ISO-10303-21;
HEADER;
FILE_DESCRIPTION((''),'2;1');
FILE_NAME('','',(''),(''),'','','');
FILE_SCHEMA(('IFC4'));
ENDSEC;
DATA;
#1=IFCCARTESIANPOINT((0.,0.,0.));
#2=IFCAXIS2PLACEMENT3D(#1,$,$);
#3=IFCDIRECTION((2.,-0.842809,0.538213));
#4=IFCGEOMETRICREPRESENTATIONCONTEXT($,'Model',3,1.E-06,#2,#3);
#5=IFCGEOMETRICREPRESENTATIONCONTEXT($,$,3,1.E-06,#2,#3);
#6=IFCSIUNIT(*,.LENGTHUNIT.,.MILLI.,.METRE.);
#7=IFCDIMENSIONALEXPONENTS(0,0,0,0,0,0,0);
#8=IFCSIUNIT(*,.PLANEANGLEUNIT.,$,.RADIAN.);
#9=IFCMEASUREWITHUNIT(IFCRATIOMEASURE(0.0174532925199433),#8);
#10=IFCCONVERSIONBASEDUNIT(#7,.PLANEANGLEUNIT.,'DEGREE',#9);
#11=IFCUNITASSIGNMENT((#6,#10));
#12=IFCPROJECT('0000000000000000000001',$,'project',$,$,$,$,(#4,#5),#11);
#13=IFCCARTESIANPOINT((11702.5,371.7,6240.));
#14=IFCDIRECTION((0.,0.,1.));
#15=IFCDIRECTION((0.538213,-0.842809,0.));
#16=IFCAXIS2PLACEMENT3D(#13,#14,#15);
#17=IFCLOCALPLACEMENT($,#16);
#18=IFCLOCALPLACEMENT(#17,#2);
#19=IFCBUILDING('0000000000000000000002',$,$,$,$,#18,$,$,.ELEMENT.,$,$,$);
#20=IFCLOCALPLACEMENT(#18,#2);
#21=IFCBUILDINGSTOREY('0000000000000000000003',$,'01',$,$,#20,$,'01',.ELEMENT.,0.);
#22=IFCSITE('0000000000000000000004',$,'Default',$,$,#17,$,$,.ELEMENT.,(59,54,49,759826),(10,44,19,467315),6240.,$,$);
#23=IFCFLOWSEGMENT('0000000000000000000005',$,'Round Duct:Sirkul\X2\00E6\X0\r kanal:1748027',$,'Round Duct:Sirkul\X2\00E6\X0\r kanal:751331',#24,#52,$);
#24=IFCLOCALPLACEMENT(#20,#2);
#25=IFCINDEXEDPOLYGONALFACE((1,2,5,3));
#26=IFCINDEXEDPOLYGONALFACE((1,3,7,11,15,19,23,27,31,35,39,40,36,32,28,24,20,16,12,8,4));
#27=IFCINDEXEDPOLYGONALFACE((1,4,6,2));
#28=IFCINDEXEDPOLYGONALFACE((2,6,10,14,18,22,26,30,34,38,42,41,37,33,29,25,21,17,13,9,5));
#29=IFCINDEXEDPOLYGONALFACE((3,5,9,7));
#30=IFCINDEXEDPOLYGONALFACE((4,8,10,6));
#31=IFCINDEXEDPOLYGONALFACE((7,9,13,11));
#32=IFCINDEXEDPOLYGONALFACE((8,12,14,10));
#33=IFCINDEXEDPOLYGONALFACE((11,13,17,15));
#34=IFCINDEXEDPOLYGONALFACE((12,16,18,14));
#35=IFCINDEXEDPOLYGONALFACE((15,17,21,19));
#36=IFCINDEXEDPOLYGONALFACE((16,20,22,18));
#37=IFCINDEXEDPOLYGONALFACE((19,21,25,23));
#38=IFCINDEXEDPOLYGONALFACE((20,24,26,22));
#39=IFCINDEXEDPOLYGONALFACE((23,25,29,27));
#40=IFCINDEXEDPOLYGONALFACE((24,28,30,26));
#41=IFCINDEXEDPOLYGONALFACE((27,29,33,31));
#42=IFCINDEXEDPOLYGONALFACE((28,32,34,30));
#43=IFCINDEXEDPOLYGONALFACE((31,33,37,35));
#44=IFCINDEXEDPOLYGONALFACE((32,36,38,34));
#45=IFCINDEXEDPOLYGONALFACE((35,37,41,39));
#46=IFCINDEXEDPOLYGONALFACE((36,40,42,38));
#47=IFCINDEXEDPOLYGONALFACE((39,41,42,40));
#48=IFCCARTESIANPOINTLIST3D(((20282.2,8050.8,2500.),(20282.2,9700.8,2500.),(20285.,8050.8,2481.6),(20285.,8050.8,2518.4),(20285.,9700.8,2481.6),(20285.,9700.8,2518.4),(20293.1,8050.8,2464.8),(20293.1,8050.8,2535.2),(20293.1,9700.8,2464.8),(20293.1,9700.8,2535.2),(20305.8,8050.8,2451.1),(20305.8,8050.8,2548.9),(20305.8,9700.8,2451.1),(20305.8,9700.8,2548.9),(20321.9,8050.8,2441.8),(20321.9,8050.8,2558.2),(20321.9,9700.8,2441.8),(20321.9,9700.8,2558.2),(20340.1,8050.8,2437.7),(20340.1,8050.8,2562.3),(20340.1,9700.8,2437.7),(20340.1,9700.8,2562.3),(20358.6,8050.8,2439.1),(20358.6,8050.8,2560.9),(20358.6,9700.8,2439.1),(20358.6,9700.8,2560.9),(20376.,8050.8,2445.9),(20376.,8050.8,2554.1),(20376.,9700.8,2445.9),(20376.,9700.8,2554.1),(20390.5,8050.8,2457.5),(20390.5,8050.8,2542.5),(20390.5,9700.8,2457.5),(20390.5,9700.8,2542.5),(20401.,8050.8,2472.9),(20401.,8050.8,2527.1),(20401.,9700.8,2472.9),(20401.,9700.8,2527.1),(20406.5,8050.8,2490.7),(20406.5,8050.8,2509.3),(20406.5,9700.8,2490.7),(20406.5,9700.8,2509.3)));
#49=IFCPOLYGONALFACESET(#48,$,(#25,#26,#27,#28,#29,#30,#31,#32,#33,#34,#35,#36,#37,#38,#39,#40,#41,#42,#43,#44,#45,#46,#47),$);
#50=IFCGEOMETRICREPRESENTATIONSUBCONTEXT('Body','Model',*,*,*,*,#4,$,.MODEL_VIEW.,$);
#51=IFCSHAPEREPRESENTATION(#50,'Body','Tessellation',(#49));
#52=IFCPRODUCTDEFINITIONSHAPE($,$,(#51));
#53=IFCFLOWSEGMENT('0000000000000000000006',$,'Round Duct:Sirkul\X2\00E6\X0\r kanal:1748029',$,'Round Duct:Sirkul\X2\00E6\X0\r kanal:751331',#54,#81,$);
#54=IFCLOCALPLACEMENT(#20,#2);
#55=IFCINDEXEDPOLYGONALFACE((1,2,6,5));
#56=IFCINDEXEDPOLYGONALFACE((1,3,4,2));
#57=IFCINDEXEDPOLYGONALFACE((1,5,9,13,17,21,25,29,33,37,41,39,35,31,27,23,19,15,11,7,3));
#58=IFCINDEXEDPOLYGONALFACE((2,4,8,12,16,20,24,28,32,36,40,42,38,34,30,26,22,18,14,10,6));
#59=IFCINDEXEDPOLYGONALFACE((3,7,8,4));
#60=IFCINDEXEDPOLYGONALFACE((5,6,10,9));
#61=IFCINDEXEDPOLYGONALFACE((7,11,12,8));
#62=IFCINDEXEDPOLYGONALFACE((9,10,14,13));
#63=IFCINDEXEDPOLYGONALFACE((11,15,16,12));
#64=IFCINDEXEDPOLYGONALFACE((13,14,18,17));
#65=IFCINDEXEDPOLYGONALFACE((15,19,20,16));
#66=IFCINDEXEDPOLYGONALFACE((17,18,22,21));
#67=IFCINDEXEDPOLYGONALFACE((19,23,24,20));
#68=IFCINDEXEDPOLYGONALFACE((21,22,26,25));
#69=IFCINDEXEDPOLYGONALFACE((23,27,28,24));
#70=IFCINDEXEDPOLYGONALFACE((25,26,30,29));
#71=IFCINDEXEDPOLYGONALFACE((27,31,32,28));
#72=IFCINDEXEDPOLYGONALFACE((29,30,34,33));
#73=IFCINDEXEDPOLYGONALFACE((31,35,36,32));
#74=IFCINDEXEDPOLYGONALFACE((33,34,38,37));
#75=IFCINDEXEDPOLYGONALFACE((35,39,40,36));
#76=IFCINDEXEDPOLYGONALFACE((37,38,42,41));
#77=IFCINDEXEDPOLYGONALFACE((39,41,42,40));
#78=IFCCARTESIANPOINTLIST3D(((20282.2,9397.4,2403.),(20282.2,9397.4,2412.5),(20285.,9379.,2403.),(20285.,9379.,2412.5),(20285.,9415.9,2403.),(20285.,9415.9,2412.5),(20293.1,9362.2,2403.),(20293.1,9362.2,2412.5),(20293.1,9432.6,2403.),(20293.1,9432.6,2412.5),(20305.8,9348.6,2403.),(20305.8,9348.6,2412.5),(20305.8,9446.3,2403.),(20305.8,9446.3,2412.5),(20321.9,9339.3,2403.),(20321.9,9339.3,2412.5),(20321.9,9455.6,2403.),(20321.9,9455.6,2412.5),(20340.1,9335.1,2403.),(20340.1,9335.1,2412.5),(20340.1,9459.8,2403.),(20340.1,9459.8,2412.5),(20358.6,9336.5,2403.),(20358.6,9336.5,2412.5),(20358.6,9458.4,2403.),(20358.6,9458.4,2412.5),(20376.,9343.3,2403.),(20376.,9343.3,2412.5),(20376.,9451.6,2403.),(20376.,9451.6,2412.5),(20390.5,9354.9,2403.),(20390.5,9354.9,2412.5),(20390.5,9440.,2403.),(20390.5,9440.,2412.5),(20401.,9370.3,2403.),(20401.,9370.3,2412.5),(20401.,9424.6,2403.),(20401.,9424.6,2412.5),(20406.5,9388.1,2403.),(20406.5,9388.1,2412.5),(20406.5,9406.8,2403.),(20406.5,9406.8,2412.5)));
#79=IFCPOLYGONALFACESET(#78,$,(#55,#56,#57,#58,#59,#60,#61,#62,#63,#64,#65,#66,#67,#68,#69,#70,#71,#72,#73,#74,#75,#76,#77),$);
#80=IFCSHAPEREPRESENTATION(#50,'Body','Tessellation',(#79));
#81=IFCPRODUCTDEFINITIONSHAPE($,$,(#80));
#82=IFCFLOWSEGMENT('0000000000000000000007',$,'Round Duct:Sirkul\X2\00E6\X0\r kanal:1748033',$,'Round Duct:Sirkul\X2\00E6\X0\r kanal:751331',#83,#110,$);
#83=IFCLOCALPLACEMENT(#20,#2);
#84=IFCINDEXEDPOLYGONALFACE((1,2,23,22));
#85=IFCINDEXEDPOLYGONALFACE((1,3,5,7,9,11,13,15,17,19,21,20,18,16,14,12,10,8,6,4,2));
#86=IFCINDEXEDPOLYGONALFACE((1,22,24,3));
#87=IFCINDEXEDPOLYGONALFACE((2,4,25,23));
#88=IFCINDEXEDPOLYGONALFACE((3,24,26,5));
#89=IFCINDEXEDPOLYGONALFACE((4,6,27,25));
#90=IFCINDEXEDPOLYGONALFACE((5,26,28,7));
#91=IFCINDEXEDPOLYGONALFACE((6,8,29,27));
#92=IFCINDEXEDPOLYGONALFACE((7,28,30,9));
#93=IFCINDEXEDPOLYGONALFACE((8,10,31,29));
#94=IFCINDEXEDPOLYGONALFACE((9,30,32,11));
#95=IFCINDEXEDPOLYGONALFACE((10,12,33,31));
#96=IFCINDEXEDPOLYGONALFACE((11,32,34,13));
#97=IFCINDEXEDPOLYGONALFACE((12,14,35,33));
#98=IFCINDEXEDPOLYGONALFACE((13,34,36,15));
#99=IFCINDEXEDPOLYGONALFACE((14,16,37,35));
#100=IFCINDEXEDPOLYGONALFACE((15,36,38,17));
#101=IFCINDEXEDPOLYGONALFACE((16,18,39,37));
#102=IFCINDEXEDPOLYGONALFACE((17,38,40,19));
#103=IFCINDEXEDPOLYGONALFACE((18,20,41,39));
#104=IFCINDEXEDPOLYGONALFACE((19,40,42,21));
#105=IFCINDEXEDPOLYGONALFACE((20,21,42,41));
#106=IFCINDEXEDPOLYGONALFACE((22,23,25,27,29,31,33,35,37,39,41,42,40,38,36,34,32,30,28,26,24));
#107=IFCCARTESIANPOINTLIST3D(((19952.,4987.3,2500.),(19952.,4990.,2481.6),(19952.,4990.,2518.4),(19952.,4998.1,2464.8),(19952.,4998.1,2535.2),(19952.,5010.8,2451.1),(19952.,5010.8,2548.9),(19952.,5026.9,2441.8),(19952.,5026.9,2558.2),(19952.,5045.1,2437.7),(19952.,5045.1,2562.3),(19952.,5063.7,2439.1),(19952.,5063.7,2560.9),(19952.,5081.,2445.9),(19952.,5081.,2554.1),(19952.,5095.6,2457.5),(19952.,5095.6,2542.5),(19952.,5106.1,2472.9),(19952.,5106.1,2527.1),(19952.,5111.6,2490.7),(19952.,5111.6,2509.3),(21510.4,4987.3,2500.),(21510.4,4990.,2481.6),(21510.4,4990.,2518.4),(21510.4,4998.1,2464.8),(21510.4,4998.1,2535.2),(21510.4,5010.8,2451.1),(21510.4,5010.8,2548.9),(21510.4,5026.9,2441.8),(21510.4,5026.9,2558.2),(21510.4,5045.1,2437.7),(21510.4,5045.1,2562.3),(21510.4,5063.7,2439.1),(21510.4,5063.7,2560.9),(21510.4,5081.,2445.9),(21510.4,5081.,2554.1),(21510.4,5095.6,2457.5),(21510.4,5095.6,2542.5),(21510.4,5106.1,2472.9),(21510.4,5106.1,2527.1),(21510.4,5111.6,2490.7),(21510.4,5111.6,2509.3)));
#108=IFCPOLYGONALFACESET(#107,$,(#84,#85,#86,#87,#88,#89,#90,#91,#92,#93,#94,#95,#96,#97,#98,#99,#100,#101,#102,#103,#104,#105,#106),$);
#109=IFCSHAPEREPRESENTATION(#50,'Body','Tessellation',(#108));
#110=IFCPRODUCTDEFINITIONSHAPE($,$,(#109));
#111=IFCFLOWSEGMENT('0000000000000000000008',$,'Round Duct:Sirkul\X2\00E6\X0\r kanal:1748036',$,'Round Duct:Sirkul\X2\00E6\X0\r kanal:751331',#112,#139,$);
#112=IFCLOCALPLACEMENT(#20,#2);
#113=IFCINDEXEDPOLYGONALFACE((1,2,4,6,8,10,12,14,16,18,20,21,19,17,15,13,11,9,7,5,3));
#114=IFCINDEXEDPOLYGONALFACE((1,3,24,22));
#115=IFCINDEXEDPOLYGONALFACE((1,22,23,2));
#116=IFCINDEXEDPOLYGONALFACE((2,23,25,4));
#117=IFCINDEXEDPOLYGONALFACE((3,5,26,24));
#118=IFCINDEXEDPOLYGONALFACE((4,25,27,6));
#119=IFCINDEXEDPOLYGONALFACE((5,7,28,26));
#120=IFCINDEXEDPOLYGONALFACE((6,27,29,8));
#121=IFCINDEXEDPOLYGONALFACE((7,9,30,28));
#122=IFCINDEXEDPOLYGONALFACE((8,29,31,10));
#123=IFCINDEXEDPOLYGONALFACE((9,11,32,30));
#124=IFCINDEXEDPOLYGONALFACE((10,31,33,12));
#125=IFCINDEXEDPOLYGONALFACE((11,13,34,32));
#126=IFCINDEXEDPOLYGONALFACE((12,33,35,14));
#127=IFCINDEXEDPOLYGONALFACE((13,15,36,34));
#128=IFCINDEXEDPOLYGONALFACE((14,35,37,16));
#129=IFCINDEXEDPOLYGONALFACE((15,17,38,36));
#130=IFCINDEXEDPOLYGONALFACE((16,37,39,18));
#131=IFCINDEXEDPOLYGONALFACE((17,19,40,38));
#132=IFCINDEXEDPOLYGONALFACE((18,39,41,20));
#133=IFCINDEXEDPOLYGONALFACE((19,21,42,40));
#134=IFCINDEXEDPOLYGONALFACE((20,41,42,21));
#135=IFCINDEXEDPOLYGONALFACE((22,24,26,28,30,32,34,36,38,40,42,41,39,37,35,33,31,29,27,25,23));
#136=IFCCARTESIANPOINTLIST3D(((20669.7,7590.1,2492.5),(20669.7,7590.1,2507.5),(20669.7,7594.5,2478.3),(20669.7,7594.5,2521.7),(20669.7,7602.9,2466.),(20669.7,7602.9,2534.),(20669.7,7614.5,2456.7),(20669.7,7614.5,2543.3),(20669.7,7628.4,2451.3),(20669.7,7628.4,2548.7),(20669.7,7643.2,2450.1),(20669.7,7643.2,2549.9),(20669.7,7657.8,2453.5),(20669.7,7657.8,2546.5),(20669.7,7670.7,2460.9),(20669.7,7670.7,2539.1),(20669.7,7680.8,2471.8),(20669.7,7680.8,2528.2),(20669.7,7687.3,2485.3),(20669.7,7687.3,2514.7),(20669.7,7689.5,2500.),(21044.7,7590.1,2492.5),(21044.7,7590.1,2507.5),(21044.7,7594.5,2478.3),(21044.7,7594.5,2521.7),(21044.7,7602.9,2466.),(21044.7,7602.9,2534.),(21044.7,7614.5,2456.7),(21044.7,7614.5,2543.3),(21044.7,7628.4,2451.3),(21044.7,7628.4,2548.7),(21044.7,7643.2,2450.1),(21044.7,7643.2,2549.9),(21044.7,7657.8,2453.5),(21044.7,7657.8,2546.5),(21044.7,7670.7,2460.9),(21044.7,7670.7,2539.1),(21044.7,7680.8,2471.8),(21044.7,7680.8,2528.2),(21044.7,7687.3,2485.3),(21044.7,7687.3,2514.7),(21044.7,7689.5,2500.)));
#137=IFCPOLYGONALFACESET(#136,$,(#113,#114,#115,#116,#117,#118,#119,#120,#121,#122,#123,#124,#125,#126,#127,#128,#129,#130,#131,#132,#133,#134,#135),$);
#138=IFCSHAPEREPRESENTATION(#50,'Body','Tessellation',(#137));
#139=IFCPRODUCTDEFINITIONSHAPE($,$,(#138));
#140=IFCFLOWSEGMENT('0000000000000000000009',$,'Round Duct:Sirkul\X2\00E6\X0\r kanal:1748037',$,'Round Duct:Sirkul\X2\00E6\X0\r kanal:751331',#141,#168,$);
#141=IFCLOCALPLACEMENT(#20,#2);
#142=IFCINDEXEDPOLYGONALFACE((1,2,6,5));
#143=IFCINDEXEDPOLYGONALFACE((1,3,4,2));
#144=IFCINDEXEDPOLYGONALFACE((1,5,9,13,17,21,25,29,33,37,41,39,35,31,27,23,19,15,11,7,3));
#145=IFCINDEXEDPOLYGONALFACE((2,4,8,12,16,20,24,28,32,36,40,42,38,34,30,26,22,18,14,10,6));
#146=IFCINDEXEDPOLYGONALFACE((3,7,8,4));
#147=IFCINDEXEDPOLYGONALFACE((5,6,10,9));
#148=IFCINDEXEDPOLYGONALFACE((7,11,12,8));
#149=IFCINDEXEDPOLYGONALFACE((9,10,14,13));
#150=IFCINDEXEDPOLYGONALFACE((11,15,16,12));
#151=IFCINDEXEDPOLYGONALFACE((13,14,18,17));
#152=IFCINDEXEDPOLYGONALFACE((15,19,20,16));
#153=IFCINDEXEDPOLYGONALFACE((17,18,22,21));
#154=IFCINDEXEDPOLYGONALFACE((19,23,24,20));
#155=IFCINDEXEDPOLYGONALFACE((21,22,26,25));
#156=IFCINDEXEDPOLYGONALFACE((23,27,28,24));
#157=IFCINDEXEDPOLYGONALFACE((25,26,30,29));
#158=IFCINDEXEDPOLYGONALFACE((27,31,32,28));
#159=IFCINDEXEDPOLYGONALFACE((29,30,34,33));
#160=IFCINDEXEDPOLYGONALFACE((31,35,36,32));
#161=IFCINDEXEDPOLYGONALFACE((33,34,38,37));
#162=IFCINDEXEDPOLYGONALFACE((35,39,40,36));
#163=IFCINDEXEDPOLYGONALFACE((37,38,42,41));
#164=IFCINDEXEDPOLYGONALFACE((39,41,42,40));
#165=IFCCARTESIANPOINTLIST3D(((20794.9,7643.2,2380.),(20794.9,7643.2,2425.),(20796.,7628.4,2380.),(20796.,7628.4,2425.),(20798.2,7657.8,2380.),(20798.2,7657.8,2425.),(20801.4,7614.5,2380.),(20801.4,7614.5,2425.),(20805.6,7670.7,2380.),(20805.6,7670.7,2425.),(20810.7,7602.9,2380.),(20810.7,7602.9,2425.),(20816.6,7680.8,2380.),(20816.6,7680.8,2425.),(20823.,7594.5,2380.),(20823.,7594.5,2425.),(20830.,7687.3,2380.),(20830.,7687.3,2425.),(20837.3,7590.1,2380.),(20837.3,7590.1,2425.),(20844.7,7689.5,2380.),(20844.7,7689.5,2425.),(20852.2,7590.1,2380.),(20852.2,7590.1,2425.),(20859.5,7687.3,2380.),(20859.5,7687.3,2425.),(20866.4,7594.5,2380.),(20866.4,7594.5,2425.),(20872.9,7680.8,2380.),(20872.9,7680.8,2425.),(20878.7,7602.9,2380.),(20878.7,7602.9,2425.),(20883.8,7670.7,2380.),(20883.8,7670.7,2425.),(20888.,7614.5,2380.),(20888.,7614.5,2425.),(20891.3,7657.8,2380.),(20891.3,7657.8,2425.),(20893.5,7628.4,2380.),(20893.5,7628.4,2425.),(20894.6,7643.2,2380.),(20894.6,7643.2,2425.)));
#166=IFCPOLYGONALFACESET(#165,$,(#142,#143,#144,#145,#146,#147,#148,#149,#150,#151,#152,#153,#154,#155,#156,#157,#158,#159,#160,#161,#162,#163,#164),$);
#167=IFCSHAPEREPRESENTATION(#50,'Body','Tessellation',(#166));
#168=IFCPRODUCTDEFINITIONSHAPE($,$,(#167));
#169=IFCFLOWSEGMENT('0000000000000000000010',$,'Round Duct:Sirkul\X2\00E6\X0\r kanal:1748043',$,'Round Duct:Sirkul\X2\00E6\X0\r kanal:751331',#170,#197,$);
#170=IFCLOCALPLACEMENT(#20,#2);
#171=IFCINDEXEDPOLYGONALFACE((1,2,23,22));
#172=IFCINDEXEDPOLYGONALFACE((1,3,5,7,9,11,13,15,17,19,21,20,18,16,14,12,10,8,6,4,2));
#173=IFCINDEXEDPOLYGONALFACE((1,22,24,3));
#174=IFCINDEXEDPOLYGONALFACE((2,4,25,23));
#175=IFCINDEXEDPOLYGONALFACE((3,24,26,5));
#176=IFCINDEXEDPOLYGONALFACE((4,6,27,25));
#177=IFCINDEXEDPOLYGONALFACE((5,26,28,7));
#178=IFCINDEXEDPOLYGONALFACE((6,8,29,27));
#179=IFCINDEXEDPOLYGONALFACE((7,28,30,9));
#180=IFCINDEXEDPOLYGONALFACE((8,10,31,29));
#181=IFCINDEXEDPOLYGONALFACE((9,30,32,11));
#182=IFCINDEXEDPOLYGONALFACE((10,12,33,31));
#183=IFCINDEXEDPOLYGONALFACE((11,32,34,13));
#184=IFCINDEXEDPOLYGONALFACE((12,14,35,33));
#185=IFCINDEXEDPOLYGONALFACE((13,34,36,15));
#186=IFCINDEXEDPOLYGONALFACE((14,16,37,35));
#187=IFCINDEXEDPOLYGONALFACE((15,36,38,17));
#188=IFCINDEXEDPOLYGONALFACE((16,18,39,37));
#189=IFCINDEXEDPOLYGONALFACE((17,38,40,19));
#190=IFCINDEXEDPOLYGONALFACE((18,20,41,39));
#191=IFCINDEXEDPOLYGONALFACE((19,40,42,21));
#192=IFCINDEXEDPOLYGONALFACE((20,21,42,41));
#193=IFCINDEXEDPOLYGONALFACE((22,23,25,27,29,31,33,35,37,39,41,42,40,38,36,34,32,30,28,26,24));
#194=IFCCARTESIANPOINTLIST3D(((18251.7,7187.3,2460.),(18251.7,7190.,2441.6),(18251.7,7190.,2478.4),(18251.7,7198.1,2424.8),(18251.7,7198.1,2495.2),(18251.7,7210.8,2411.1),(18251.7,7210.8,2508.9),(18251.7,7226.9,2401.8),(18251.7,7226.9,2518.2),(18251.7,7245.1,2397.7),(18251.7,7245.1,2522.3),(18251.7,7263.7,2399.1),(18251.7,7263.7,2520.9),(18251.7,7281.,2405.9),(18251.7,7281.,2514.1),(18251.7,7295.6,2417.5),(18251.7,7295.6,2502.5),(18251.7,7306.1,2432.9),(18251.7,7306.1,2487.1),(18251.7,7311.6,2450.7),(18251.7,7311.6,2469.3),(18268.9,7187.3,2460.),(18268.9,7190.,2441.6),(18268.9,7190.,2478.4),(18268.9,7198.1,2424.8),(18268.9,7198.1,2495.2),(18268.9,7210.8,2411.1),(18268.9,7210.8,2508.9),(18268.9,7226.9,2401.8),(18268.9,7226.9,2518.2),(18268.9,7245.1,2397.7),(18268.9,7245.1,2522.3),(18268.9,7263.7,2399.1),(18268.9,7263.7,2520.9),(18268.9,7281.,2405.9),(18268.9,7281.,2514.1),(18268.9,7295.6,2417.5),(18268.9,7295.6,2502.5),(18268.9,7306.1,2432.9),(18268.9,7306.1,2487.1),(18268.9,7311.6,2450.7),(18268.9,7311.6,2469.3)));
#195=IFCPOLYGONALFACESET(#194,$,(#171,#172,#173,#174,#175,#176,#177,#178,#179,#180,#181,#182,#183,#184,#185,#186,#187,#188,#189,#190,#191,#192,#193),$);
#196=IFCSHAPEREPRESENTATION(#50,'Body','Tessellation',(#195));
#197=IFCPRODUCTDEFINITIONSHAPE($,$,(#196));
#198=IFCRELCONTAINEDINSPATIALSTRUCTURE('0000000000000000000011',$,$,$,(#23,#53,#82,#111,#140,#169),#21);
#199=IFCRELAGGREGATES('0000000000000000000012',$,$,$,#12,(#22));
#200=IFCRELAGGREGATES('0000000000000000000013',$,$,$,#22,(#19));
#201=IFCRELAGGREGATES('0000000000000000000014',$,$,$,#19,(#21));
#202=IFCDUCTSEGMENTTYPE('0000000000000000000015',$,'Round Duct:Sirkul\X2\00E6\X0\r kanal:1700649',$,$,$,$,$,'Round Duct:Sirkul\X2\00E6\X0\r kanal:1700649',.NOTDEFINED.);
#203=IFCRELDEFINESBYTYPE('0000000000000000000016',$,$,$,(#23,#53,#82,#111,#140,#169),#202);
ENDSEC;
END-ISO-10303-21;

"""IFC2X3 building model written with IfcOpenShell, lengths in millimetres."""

from ifc_helpers import new_model, entity, si_unit, converted_unit, direction, frame, frame_2d, origin, origin_2d_with_axis, place, context, subcontext, project, spatial, circle, extrude, type_object, element, save


model = new_model("IFC2X3")

# Units and contexts
model_context = context("Model", 3, precision=1e-06, world=origin(), true_north=direction((2.0, -0.842809, 0.538213)))
context_of_model = context(None, 3, precision=1e-06, world=origin(), true_north=direction((2.0, -0.842809, 0.538213)))
body_context = subcontext(model_context, "Body", "Model", "MODEL_VIEW")
ifc_project = project(units=[si_unit("LENGTHUNIT", "METRE", prefix="MILLI"), converted_unit("PLANEANGLEUNIT", "DEGREE", entity("IfcRatioMeasure", 0.0174532925199433), si_unit("PLANEANGLEUNIT", "RADIAN"), dimensions=[0, 0, 0, 0, 0, 0, 0])], contexts=[model_context, context_of_model])

# Site, building, storey
site_placement = place(None, frame((11702.5, 371.7, 6240.0), z_axis=(0.0, 0.0, 1.0), x_axis=(0.538213, -0.842809, 0.0)))
site = spatial("IfcSite", under=ifc_project, at=site_placement, Name="Default", CompositionType="ELEMENT", RefLatitude=(59, 54, 49, 759826), RefLongitude=(10, 44, 19, 467315), RefElevation=6240.0)
building_placement = place(site_placement, origin())
building = spatial("IfcBuilding", under=site, at=building_placement, CompositionType="ELEMENT")
storey_placement = place(building_placement, origin())
storey = spatial("IfcBuildingStorey", under=building, at=storey_placement, Name="01", LongName="01", CompositionType="ELEMENT", Elevation=0.0)

# Flow segments
duct_segment_type_1 = type_object("IfcDuctSegmentType", Name="Round Duct:Sirkulær kanal:1700649", ElementType="Round Duct:Sirkulær kanal:1700649", PredefinedType="NOTDEFINED")
flow_segment_1_placement = place(storey_placement, origin())
element("IfcFlowSegment", 1, at=flow_segment_1_placement, inside=storey, type_object=duct_segment_type_1, Name="Round Duct:Sirkulær kanal:1748027", ObjectType="Round Duct:Sirkulær kanal:751331", context=body_context, shape_type="SweptSolid", body=[
    extrude(circle(Radius=62.5, at=frame_2d((0.0, 0.0), x_axis=(1.0, 0.0))), frame((20344.7, 8050.8, 2500.0), z_axis=(0.0, 1.0, 0.0), x_axis=(-1.0, 0.0, 0.0)), (0.0, 0.0, 1.0), 1650.0),
])
flow_segment_2_placement = place(storey_placement, origin())
element("IfcFlowSegment", 2, at=flow_segment_2_placement, inside=storey, type_object=duct_segment_type_1, Name="Round Duct:Sirkulær kanal:1748029", ObjectType="Round Duct:Sirkulær kanal:751331", context=body_context, shape_type="SweptSolid", body=[
    extrude(circle(Radius=62.5, at=origin_2d_with_axis()), frame((20344.7, 9397.4, 2403.0), z_axis=(0.0, 0.0, 1.0), x_axis=(-1.0, 0.0, 0.0)), (0.0, 0.0, 1.0), 9.5),
])
flow_segment_3_placement = place(storey_placement, origin())
element("IfcFlowSegment", 3, at=flow_segment_3_placement, inside=storey, type_object=duct_segment_type_1, Name="Round Duct:Sirkulær kanal:1748033", ObjectType="Round Duct:Sirkulær kanal:751331", context=body_context, shape_type="SweptSolid", body=[
    extrude(circle(Radius=62.5, at=origin_2d_with_axis()), frame((19952.0, 5049.8, 2500.0), z_axis=(1.0, 0.0, 0.0), x_axis=(0.0, -1.0, 0.0)), (0.0, 0.0, 1.0), 1558.4),
])
flow_segment_4_placement = place(storey_placement, origin())
element("IfcFlowSegment", 4, at=flow_segment_4_placement, inside=storey, type_object=duct_segment_type_1, Name="Round Duct:Sirkulær kanal:1748036", ObjectType="Round Duct:Sirkulær kanal:751331", context=body_context, shape_type="SweptSolid", body=[
    extrude(circle(Radius=50.0, at=frame_2d((0.0, 0.0), x_axis=(1.0, 0.0))), frame((20669.7, 7639.5, 2500.0), z_axis=(1.0, 0.0, 0.0), x_axis=(0.0, 1.0, 0.0)), (0.0, 0.0, 1.0), 375.0),
])
flow_segment_5_placement = place(storey_placement, origin())
element("IfcFlowSegment", 5, at=flow_segment_5_placement, inside=storey, type_object=duct_segment_type_1, Name="Round Duct:Sirkulær kanal:1748037", ObjectType="Round Duct:Sirkulær kanal:751331", context=body_context, shape_type="SweptSolid", body=[
    extrude(circle(Radius=50.0, at=frame_2d((0.0, 0.0), x_axis=(1.0, 0.0))), frame((20844.7, 7639.5, 2380.0), z_axis=(0.0, 0.0, 1.0), x_axis=(0.0, 1.0, 0.0)), (0.0, 0.0, 1.0), 45.0),
])
flow_segment_6_placement = place(storey_placement, origin())
element("IfcFlowSegment", 6, at=flow_segment_6_placement, inside=storey, type_object=duct_segment_type_1, Name="Round Duct:Sirkulær kanal:1748043", ObjectType="Round Duct:Sirkulær kanal:751331", context=body_context, shape_type="SweptSolid", body=[
    extrude(circle(Radius=62.5, at=origin_2d_with_axis()), frame((18251.7, 7249.8, 2460.0), z_axis=(1.0, 0.0, 0.0), x_axis=(0.0, -1.0, 0.0)), (0.0, 0.0, 1.0), 17.1),
])

save(model, "model.ifc")
